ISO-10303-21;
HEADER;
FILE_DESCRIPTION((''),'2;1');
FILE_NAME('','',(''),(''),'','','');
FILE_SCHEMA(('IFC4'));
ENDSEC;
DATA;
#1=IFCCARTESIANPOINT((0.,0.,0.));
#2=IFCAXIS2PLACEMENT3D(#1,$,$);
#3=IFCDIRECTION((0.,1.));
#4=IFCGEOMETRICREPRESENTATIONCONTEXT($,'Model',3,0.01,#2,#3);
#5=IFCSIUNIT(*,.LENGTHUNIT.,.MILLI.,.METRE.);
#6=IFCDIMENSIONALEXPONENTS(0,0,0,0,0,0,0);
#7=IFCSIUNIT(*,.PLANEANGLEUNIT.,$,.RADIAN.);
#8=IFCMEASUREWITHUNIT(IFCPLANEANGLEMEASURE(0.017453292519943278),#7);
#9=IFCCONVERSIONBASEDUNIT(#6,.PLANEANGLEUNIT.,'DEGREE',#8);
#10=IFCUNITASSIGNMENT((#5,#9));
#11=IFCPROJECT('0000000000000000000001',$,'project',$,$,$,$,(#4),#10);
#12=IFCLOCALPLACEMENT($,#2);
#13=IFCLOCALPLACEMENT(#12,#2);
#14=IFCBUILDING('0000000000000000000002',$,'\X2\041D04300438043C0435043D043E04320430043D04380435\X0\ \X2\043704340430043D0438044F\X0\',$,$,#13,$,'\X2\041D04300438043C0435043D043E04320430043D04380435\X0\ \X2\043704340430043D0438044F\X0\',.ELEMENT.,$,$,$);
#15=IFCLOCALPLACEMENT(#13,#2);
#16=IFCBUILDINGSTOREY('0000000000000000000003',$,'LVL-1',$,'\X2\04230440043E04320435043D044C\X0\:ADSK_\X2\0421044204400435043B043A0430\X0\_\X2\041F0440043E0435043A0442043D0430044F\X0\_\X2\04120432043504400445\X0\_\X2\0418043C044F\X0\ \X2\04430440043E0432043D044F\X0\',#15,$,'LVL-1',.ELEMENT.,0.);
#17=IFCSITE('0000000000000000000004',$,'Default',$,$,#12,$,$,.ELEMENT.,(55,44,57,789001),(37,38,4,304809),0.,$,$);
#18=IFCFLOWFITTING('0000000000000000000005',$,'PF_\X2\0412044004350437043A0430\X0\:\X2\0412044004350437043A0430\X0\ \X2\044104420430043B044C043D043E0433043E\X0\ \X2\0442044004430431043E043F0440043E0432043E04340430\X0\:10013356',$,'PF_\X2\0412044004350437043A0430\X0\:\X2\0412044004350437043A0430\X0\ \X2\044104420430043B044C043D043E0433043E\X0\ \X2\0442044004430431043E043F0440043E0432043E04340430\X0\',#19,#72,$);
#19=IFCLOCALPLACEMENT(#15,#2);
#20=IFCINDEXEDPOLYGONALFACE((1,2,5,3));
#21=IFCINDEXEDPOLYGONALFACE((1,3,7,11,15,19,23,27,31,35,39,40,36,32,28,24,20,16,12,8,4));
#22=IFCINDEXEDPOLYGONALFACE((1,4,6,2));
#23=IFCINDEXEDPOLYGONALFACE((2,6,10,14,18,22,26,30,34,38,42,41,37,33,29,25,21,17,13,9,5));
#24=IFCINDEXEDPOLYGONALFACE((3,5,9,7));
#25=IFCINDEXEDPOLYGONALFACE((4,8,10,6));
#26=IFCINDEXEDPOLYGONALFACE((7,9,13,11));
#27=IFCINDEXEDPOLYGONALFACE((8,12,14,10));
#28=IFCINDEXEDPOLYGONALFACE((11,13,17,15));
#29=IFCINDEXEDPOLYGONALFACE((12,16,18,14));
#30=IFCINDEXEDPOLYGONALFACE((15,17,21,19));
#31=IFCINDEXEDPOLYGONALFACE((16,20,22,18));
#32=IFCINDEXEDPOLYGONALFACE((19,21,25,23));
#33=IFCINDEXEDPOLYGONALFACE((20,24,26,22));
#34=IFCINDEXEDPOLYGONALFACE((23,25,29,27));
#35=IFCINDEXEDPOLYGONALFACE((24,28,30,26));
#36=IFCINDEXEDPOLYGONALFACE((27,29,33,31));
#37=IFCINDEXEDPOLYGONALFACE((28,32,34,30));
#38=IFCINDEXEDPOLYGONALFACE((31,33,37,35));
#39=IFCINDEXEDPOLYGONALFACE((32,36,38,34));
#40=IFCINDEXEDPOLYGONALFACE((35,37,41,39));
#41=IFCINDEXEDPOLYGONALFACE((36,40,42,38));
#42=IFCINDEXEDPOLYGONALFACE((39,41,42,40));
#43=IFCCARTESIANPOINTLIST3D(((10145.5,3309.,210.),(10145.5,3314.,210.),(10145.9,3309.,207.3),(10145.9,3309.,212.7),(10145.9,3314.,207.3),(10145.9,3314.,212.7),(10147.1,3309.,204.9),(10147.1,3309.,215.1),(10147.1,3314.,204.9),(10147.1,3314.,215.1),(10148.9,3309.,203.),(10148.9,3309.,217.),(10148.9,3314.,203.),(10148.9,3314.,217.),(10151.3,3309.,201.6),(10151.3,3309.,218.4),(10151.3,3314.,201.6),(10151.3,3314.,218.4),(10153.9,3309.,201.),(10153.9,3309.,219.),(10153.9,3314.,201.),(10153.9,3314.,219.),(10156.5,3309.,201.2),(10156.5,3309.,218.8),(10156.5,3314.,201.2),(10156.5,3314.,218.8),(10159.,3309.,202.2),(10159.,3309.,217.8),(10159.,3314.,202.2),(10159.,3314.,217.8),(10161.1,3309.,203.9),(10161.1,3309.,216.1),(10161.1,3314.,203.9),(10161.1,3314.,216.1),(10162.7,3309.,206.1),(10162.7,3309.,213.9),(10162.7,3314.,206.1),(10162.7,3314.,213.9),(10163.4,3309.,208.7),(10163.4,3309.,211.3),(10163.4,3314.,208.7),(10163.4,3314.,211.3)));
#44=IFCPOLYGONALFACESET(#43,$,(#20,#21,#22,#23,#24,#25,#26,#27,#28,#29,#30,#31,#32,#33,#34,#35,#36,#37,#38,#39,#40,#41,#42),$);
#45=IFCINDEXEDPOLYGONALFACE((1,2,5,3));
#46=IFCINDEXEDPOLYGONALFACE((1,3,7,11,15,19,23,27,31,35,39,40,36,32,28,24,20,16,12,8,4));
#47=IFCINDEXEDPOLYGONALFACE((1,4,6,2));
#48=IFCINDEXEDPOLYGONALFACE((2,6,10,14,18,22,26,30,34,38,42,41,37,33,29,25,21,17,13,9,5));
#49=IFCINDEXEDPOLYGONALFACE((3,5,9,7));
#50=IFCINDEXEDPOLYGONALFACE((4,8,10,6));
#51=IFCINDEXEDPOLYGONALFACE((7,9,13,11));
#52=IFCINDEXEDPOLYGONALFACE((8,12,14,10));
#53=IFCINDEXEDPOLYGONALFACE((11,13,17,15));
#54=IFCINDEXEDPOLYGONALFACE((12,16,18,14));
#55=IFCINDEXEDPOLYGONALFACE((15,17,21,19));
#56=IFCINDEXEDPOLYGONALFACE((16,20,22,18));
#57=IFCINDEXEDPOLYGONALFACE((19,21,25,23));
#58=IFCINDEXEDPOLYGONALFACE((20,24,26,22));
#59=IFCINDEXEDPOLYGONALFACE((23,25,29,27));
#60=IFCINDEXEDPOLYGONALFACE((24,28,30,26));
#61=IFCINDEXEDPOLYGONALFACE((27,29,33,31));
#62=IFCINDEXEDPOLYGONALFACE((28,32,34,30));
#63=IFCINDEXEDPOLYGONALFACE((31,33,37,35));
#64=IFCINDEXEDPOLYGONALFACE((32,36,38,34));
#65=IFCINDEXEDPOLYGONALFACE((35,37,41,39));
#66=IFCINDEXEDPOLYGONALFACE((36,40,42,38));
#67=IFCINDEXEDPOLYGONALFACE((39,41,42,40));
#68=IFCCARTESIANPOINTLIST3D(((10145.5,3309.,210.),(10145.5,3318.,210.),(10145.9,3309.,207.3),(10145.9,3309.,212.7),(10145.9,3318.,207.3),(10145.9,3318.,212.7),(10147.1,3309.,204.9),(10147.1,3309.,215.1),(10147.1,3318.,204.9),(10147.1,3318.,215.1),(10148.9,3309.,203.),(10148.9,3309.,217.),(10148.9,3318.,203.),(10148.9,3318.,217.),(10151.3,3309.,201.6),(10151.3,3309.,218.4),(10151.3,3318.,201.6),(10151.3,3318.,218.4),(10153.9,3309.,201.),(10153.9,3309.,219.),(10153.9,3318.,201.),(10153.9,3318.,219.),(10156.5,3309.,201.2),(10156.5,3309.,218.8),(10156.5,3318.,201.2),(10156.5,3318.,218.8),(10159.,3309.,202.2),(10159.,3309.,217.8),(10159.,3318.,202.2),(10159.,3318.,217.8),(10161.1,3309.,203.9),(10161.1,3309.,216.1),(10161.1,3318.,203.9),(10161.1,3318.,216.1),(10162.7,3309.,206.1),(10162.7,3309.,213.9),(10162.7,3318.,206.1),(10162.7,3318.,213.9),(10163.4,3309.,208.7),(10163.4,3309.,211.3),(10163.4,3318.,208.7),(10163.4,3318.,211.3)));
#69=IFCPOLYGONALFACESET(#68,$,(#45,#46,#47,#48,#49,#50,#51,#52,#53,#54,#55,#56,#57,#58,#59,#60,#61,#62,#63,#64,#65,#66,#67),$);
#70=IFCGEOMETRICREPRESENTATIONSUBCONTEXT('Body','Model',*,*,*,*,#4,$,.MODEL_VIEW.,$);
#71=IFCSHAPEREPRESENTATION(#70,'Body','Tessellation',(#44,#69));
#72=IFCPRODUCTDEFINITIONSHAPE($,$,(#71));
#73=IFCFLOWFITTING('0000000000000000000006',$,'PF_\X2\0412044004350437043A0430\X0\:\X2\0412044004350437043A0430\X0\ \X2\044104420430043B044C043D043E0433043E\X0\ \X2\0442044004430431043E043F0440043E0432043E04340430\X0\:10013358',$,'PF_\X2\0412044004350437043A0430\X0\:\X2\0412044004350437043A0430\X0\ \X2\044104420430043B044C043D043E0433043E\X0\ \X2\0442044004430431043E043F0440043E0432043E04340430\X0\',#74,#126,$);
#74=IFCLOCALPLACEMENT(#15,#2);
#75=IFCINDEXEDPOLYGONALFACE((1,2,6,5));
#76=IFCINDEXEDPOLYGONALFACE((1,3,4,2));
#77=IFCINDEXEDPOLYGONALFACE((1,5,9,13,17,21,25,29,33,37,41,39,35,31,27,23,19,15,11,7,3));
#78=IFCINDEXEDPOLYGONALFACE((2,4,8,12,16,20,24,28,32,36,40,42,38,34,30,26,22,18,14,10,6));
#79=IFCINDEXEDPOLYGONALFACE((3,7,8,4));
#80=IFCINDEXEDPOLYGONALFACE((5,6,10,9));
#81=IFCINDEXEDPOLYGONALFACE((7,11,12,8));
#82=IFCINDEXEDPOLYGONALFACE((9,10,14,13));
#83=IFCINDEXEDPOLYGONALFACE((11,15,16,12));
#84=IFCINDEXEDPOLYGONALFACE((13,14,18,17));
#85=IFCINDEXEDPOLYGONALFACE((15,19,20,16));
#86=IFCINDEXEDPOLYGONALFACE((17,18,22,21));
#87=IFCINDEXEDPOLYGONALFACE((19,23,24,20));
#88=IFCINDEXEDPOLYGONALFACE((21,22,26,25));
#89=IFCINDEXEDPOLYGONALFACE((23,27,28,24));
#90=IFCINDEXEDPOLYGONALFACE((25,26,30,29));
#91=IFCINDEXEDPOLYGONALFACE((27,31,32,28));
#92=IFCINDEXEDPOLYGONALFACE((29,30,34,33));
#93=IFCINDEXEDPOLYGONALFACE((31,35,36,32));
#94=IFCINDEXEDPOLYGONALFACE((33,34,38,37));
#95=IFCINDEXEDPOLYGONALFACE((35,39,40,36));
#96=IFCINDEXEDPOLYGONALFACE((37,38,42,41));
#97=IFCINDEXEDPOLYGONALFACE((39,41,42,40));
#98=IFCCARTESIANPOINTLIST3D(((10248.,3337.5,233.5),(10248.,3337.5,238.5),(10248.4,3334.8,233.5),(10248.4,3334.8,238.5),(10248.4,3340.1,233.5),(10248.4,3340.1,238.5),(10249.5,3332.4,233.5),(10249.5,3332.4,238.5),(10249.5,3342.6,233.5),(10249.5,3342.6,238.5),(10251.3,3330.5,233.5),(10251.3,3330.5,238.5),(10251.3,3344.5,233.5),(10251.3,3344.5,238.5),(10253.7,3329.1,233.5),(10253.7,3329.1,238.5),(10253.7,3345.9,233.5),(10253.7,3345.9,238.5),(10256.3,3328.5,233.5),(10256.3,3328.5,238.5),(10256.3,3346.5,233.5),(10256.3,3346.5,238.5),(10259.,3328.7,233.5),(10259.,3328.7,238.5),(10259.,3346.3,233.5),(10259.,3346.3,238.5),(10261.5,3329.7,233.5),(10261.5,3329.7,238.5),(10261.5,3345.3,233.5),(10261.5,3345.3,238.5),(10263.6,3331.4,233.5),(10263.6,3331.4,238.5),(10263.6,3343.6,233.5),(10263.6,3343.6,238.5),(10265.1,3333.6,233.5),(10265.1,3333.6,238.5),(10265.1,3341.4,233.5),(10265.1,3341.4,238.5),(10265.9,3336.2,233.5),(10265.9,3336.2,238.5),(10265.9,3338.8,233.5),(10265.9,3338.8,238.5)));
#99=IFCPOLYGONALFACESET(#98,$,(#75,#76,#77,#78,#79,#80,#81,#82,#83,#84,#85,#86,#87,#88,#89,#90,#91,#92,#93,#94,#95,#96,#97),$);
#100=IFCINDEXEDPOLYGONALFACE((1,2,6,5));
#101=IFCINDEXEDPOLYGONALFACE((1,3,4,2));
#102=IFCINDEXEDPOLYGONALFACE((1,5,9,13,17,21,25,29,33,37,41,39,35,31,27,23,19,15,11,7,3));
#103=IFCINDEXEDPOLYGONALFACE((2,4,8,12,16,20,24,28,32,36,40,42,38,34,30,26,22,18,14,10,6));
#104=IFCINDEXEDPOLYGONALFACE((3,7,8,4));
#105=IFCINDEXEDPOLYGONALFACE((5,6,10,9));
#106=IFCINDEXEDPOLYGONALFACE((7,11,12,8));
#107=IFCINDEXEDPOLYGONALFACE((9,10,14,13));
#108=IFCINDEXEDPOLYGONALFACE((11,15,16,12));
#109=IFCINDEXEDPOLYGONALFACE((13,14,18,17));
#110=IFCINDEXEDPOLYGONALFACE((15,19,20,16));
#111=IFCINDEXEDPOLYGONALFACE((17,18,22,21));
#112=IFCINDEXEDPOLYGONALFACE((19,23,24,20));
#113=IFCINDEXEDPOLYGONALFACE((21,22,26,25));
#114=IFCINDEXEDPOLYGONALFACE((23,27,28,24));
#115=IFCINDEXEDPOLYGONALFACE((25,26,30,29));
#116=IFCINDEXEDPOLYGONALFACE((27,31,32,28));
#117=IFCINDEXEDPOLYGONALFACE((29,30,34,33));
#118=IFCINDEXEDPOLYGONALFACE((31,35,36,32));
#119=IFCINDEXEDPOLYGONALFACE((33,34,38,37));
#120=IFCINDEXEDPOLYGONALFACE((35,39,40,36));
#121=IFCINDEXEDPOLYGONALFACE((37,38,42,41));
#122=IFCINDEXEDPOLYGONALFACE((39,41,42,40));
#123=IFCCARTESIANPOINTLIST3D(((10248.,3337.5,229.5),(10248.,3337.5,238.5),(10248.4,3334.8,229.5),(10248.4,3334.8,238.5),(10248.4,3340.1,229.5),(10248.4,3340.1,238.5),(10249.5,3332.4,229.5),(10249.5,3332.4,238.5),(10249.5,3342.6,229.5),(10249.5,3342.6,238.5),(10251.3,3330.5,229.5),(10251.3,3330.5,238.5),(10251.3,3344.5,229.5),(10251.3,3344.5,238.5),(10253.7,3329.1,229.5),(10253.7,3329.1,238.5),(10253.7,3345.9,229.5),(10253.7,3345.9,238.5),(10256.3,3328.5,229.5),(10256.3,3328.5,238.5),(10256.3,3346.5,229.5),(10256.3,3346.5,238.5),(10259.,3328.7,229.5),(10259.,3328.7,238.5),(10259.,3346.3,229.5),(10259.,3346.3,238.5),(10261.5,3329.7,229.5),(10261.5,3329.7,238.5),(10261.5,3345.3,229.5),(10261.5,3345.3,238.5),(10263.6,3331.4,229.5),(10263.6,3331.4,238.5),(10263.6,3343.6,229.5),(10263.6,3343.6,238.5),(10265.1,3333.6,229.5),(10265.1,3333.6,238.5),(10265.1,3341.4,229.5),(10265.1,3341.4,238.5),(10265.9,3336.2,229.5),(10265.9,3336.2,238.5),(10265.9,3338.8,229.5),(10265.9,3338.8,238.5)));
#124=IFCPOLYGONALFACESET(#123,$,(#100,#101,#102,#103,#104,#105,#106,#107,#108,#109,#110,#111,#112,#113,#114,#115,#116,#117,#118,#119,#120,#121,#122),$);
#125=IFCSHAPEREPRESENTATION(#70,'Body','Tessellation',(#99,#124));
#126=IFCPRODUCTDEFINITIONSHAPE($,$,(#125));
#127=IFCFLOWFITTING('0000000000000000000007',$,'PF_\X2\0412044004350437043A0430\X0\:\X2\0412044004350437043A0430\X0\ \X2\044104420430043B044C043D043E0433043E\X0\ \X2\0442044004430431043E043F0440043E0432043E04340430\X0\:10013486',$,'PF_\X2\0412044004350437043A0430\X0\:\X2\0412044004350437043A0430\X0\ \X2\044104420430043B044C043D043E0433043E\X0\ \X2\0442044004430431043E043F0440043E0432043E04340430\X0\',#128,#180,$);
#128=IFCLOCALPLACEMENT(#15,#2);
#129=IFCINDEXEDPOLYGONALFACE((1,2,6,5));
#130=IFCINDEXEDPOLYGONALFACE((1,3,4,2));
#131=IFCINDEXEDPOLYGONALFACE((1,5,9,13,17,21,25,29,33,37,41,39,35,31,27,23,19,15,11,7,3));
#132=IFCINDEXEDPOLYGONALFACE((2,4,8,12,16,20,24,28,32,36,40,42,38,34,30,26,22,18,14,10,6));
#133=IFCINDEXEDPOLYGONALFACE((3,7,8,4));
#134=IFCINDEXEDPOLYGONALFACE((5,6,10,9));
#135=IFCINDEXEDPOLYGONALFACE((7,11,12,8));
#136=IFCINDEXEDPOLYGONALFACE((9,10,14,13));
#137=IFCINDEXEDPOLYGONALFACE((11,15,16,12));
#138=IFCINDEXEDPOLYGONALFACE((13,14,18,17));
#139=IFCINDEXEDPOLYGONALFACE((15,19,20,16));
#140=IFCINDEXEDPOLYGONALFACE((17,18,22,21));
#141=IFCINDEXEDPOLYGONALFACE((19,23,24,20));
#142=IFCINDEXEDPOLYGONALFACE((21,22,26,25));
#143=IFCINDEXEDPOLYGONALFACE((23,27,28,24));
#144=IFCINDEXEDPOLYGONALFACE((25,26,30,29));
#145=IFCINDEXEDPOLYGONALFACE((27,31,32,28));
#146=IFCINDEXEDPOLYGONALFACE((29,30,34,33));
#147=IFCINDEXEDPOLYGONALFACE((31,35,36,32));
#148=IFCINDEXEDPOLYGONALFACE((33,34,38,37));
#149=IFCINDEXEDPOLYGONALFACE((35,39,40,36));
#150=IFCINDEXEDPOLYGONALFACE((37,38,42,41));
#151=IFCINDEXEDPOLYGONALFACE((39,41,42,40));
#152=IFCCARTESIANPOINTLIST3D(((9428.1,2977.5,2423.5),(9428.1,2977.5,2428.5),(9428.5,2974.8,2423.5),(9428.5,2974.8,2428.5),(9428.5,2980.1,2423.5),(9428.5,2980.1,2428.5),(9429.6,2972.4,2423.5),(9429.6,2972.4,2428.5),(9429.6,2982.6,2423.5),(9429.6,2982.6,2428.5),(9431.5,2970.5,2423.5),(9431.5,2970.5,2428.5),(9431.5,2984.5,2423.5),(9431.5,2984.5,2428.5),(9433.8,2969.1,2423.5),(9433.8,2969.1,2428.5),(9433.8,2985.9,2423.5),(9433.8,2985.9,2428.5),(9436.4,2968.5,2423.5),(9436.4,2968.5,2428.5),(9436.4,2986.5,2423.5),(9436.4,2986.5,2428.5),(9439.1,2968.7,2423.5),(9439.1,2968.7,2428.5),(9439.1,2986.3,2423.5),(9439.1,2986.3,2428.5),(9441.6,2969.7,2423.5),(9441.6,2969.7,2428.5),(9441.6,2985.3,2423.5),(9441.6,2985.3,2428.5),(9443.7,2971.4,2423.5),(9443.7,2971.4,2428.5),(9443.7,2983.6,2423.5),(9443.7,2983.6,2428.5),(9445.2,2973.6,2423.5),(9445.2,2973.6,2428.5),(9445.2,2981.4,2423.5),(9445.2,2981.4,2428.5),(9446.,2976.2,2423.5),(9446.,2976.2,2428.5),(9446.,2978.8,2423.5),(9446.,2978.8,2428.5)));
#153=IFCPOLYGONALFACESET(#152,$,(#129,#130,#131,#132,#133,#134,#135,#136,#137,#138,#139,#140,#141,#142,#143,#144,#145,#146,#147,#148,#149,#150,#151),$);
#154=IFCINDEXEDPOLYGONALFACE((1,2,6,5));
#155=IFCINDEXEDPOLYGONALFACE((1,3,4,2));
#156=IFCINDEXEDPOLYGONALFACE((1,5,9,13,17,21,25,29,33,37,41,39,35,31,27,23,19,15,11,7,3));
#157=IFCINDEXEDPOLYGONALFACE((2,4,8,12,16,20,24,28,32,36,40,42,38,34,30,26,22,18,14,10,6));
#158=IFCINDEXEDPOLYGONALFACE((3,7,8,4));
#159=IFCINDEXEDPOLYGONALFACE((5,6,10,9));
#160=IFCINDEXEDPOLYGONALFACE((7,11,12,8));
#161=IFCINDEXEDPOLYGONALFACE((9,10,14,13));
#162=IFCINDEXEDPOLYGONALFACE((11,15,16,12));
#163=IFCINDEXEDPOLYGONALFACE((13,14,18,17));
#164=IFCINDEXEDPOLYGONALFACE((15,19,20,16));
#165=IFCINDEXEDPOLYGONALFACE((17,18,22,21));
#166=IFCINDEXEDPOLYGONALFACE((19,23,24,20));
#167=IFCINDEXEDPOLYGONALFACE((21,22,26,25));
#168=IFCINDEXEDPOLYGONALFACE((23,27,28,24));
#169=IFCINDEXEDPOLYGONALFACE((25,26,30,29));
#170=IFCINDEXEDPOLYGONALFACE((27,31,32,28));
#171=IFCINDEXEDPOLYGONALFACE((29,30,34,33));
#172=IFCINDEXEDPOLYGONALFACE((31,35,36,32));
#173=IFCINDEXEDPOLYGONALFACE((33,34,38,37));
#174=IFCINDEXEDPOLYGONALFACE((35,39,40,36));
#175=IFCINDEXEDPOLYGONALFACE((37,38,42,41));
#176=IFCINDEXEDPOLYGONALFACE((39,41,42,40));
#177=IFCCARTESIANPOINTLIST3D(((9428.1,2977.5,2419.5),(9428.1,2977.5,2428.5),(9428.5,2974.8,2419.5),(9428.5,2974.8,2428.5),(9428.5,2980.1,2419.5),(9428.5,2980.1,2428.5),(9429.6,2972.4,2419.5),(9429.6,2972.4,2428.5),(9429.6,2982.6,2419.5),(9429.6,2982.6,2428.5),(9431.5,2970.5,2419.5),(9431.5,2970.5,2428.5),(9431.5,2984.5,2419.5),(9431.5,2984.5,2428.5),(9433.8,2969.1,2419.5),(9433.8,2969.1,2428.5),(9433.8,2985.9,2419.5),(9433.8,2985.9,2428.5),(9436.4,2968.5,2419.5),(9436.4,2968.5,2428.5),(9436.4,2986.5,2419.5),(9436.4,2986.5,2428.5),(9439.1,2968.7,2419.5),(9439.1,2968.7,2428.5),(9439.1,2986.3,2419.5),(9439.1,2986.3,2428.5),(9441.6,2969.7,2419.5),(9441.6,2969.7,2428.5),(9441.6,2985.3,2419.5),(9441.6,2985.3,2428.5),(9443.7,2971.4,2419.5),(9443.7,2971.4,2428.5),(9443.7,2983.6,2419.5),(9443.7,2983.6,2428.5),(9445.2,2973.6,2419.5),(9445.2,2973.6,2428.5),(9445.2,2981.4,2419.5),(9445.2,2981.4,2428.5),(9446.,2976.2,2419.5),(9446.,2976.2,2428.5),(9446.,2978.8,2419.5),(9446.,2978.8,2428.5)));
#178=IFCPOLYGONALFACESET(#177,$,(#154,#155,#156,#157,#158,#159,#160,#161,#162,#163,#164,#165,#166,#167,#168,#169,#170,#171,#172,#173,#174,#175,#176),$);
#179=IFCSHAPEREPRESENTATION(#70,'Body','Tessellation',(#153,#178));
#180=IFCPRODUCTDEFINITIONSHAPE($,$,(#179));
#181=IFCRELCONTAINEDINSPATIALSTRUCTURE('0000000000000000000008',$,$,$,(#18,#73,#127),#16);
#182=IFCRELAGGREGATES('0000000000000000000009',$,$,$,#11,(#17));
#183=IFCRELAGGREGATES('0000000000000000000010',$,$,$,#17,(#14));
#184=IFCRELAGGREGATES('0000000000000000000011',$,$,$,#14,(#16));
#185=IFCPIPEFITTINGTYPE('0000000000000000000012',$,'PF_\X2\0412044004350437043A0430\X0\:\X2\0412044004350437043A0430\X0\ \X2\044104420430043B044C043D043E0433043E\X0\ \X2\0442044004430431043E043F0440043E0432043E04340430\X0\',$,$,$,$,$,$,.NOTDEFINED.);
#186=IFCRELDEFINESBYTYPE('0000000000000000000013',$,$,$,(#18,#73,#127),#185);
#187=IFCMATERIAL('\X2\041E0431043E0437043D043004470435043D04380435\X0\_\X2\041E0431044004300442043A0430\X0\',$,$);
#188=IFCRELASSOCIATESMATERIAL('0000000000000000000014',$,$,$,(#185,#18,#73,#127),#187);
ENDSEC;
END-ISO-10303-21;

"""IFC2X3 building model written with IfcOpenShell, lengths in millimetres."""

from ifc_helpers import new_model, entity, si_unit, converted_unit, direction, frame, frame_2d, origin, place, context, subcontext, project, spatial, circle, extrude, source, transform, mapped, material, type_object, type_shapes, element, save


model = new_model("IFC2X3")

# Units and contexts
model_context = context("Model", 3, precision=0.01, world=origin(), true_north=direction((0.0, 1.0)))
body_context = subcontext(model_context, "Body", "Model", "MODEL_VIEW")
ifc_project = project(units=[si_unit("LENGTHUNIT", "METRE", prefix="MILLI"), converted_unit("PLANEANGLEUNIT", "DEGREE", entity("IfcPlaneAngleMeasure", 0.017453292519943278), si_unit("PLANEANGLEUNIT", "RADIAN"), dimensions=[0, 0, 0, 0, 0, 0, 0])], contexts=[model_context])

# Site, building, storey
site_placement = place(None, origin())
site = spatial("IfcSite", under=ifc_project, at=site_placement, Name="Default", CompositionType="ELEMENT", RefLatitude=(55, 44, 57, 789001), RefLongitude=(37, 38, 4, 304809), RefElevation=0.0)
building_placement = place(site_placement, origin())
building = spatial("IfcBuilding", under=site, at=building_placement, Name="Наименование здания", LongName="Наименование здания", CompositionType="ELEMENT")
storey_placement = place(building_placement, origin())
storey = spatial("IfcBuildingStorey", under=building, at=storey_placement, Name="LVL-1", ObjectType="Уровень:ADSK_Стрелка_Проектная_Вверх_Имя уровня", LongName="LVL-1", CompositionType="ELEMENT", Elevation=0.0)

# Flow fittings
ifc_material_1 = material(Name="Обозначение_Обратка")
pipe_fitting_type_1 = type_object("IfcPipeFittingType", Name="PF_Врезка:Врезка стального трубопровода", PredefinedType="NOTDEFINED", material=ifc_material_1)
shared_shape_1 = source(origin(), body_context, "Body", "SweptSolid", [
    extrude(circle(Radius=9.0, at=frame_2d((0.0, 0.0), x_axis=(1.0, 0.0))), frame((-5.0, 0.0, 0.0), z_axis=(1.0, 0.0, 0.0), x_axis=(0.0, 1.0, 0.0)), (0.0, 0.0, 1.0), 5.0),
    extrude(circle(Radius=9.0, at=frame_2d((0.0, 0.0), x_axis=(1.0, 0.0))), frame((-9.0, 0.0, 0.0), z_axis=(1.0, 0.0, 0.0), x_axis=(0.0, 1.0, 0.0)), (0.0, 0.0, 1.0), 9.0),
])
type_shapes(pipe_fitting_type_1, [shared_shape_1])
for number, where, z_axis, x_axis, name in (
    (1, (10154.5, 3309.0, 210.0), (0.0, 0.0, -1.0), (0.0, -1.0, 0.0), "PF_Врезка:Врезка стального трубопровода:10013356"),
    (2, (10257.0, 3337.5, 238.5), (0.0, -1.0, 0.0), (0.0, 0.0, 1.0), "PF_Врезка:Врезка стального трубопровода:10013358"),
    (3, (9437.1, 2977.5, 2428.5), (0.0, -1.0, 0.0), (0.0, 0.0, 1.0), "PF_Врезка:Врезка стального трубопровода:10013486"),
):
    element("IfcFlowFitting", number, at=place(storey_placement, frame(where, z_axis=z_axis, x_axis=x_axis)), inside=storey, type_object=pipe_fitting_type_1, material=ifc_material_1, Name=name, ObjectType="PF_Врезка:Врезка стального трубопровода", context=body_context, shape_type="MappedRepresentation", body=[
        mapped(shared_shape_1, transform((0.0, 0.0, 0.0), scale=1.0)),
    ])

save(model, "model.ifc")
